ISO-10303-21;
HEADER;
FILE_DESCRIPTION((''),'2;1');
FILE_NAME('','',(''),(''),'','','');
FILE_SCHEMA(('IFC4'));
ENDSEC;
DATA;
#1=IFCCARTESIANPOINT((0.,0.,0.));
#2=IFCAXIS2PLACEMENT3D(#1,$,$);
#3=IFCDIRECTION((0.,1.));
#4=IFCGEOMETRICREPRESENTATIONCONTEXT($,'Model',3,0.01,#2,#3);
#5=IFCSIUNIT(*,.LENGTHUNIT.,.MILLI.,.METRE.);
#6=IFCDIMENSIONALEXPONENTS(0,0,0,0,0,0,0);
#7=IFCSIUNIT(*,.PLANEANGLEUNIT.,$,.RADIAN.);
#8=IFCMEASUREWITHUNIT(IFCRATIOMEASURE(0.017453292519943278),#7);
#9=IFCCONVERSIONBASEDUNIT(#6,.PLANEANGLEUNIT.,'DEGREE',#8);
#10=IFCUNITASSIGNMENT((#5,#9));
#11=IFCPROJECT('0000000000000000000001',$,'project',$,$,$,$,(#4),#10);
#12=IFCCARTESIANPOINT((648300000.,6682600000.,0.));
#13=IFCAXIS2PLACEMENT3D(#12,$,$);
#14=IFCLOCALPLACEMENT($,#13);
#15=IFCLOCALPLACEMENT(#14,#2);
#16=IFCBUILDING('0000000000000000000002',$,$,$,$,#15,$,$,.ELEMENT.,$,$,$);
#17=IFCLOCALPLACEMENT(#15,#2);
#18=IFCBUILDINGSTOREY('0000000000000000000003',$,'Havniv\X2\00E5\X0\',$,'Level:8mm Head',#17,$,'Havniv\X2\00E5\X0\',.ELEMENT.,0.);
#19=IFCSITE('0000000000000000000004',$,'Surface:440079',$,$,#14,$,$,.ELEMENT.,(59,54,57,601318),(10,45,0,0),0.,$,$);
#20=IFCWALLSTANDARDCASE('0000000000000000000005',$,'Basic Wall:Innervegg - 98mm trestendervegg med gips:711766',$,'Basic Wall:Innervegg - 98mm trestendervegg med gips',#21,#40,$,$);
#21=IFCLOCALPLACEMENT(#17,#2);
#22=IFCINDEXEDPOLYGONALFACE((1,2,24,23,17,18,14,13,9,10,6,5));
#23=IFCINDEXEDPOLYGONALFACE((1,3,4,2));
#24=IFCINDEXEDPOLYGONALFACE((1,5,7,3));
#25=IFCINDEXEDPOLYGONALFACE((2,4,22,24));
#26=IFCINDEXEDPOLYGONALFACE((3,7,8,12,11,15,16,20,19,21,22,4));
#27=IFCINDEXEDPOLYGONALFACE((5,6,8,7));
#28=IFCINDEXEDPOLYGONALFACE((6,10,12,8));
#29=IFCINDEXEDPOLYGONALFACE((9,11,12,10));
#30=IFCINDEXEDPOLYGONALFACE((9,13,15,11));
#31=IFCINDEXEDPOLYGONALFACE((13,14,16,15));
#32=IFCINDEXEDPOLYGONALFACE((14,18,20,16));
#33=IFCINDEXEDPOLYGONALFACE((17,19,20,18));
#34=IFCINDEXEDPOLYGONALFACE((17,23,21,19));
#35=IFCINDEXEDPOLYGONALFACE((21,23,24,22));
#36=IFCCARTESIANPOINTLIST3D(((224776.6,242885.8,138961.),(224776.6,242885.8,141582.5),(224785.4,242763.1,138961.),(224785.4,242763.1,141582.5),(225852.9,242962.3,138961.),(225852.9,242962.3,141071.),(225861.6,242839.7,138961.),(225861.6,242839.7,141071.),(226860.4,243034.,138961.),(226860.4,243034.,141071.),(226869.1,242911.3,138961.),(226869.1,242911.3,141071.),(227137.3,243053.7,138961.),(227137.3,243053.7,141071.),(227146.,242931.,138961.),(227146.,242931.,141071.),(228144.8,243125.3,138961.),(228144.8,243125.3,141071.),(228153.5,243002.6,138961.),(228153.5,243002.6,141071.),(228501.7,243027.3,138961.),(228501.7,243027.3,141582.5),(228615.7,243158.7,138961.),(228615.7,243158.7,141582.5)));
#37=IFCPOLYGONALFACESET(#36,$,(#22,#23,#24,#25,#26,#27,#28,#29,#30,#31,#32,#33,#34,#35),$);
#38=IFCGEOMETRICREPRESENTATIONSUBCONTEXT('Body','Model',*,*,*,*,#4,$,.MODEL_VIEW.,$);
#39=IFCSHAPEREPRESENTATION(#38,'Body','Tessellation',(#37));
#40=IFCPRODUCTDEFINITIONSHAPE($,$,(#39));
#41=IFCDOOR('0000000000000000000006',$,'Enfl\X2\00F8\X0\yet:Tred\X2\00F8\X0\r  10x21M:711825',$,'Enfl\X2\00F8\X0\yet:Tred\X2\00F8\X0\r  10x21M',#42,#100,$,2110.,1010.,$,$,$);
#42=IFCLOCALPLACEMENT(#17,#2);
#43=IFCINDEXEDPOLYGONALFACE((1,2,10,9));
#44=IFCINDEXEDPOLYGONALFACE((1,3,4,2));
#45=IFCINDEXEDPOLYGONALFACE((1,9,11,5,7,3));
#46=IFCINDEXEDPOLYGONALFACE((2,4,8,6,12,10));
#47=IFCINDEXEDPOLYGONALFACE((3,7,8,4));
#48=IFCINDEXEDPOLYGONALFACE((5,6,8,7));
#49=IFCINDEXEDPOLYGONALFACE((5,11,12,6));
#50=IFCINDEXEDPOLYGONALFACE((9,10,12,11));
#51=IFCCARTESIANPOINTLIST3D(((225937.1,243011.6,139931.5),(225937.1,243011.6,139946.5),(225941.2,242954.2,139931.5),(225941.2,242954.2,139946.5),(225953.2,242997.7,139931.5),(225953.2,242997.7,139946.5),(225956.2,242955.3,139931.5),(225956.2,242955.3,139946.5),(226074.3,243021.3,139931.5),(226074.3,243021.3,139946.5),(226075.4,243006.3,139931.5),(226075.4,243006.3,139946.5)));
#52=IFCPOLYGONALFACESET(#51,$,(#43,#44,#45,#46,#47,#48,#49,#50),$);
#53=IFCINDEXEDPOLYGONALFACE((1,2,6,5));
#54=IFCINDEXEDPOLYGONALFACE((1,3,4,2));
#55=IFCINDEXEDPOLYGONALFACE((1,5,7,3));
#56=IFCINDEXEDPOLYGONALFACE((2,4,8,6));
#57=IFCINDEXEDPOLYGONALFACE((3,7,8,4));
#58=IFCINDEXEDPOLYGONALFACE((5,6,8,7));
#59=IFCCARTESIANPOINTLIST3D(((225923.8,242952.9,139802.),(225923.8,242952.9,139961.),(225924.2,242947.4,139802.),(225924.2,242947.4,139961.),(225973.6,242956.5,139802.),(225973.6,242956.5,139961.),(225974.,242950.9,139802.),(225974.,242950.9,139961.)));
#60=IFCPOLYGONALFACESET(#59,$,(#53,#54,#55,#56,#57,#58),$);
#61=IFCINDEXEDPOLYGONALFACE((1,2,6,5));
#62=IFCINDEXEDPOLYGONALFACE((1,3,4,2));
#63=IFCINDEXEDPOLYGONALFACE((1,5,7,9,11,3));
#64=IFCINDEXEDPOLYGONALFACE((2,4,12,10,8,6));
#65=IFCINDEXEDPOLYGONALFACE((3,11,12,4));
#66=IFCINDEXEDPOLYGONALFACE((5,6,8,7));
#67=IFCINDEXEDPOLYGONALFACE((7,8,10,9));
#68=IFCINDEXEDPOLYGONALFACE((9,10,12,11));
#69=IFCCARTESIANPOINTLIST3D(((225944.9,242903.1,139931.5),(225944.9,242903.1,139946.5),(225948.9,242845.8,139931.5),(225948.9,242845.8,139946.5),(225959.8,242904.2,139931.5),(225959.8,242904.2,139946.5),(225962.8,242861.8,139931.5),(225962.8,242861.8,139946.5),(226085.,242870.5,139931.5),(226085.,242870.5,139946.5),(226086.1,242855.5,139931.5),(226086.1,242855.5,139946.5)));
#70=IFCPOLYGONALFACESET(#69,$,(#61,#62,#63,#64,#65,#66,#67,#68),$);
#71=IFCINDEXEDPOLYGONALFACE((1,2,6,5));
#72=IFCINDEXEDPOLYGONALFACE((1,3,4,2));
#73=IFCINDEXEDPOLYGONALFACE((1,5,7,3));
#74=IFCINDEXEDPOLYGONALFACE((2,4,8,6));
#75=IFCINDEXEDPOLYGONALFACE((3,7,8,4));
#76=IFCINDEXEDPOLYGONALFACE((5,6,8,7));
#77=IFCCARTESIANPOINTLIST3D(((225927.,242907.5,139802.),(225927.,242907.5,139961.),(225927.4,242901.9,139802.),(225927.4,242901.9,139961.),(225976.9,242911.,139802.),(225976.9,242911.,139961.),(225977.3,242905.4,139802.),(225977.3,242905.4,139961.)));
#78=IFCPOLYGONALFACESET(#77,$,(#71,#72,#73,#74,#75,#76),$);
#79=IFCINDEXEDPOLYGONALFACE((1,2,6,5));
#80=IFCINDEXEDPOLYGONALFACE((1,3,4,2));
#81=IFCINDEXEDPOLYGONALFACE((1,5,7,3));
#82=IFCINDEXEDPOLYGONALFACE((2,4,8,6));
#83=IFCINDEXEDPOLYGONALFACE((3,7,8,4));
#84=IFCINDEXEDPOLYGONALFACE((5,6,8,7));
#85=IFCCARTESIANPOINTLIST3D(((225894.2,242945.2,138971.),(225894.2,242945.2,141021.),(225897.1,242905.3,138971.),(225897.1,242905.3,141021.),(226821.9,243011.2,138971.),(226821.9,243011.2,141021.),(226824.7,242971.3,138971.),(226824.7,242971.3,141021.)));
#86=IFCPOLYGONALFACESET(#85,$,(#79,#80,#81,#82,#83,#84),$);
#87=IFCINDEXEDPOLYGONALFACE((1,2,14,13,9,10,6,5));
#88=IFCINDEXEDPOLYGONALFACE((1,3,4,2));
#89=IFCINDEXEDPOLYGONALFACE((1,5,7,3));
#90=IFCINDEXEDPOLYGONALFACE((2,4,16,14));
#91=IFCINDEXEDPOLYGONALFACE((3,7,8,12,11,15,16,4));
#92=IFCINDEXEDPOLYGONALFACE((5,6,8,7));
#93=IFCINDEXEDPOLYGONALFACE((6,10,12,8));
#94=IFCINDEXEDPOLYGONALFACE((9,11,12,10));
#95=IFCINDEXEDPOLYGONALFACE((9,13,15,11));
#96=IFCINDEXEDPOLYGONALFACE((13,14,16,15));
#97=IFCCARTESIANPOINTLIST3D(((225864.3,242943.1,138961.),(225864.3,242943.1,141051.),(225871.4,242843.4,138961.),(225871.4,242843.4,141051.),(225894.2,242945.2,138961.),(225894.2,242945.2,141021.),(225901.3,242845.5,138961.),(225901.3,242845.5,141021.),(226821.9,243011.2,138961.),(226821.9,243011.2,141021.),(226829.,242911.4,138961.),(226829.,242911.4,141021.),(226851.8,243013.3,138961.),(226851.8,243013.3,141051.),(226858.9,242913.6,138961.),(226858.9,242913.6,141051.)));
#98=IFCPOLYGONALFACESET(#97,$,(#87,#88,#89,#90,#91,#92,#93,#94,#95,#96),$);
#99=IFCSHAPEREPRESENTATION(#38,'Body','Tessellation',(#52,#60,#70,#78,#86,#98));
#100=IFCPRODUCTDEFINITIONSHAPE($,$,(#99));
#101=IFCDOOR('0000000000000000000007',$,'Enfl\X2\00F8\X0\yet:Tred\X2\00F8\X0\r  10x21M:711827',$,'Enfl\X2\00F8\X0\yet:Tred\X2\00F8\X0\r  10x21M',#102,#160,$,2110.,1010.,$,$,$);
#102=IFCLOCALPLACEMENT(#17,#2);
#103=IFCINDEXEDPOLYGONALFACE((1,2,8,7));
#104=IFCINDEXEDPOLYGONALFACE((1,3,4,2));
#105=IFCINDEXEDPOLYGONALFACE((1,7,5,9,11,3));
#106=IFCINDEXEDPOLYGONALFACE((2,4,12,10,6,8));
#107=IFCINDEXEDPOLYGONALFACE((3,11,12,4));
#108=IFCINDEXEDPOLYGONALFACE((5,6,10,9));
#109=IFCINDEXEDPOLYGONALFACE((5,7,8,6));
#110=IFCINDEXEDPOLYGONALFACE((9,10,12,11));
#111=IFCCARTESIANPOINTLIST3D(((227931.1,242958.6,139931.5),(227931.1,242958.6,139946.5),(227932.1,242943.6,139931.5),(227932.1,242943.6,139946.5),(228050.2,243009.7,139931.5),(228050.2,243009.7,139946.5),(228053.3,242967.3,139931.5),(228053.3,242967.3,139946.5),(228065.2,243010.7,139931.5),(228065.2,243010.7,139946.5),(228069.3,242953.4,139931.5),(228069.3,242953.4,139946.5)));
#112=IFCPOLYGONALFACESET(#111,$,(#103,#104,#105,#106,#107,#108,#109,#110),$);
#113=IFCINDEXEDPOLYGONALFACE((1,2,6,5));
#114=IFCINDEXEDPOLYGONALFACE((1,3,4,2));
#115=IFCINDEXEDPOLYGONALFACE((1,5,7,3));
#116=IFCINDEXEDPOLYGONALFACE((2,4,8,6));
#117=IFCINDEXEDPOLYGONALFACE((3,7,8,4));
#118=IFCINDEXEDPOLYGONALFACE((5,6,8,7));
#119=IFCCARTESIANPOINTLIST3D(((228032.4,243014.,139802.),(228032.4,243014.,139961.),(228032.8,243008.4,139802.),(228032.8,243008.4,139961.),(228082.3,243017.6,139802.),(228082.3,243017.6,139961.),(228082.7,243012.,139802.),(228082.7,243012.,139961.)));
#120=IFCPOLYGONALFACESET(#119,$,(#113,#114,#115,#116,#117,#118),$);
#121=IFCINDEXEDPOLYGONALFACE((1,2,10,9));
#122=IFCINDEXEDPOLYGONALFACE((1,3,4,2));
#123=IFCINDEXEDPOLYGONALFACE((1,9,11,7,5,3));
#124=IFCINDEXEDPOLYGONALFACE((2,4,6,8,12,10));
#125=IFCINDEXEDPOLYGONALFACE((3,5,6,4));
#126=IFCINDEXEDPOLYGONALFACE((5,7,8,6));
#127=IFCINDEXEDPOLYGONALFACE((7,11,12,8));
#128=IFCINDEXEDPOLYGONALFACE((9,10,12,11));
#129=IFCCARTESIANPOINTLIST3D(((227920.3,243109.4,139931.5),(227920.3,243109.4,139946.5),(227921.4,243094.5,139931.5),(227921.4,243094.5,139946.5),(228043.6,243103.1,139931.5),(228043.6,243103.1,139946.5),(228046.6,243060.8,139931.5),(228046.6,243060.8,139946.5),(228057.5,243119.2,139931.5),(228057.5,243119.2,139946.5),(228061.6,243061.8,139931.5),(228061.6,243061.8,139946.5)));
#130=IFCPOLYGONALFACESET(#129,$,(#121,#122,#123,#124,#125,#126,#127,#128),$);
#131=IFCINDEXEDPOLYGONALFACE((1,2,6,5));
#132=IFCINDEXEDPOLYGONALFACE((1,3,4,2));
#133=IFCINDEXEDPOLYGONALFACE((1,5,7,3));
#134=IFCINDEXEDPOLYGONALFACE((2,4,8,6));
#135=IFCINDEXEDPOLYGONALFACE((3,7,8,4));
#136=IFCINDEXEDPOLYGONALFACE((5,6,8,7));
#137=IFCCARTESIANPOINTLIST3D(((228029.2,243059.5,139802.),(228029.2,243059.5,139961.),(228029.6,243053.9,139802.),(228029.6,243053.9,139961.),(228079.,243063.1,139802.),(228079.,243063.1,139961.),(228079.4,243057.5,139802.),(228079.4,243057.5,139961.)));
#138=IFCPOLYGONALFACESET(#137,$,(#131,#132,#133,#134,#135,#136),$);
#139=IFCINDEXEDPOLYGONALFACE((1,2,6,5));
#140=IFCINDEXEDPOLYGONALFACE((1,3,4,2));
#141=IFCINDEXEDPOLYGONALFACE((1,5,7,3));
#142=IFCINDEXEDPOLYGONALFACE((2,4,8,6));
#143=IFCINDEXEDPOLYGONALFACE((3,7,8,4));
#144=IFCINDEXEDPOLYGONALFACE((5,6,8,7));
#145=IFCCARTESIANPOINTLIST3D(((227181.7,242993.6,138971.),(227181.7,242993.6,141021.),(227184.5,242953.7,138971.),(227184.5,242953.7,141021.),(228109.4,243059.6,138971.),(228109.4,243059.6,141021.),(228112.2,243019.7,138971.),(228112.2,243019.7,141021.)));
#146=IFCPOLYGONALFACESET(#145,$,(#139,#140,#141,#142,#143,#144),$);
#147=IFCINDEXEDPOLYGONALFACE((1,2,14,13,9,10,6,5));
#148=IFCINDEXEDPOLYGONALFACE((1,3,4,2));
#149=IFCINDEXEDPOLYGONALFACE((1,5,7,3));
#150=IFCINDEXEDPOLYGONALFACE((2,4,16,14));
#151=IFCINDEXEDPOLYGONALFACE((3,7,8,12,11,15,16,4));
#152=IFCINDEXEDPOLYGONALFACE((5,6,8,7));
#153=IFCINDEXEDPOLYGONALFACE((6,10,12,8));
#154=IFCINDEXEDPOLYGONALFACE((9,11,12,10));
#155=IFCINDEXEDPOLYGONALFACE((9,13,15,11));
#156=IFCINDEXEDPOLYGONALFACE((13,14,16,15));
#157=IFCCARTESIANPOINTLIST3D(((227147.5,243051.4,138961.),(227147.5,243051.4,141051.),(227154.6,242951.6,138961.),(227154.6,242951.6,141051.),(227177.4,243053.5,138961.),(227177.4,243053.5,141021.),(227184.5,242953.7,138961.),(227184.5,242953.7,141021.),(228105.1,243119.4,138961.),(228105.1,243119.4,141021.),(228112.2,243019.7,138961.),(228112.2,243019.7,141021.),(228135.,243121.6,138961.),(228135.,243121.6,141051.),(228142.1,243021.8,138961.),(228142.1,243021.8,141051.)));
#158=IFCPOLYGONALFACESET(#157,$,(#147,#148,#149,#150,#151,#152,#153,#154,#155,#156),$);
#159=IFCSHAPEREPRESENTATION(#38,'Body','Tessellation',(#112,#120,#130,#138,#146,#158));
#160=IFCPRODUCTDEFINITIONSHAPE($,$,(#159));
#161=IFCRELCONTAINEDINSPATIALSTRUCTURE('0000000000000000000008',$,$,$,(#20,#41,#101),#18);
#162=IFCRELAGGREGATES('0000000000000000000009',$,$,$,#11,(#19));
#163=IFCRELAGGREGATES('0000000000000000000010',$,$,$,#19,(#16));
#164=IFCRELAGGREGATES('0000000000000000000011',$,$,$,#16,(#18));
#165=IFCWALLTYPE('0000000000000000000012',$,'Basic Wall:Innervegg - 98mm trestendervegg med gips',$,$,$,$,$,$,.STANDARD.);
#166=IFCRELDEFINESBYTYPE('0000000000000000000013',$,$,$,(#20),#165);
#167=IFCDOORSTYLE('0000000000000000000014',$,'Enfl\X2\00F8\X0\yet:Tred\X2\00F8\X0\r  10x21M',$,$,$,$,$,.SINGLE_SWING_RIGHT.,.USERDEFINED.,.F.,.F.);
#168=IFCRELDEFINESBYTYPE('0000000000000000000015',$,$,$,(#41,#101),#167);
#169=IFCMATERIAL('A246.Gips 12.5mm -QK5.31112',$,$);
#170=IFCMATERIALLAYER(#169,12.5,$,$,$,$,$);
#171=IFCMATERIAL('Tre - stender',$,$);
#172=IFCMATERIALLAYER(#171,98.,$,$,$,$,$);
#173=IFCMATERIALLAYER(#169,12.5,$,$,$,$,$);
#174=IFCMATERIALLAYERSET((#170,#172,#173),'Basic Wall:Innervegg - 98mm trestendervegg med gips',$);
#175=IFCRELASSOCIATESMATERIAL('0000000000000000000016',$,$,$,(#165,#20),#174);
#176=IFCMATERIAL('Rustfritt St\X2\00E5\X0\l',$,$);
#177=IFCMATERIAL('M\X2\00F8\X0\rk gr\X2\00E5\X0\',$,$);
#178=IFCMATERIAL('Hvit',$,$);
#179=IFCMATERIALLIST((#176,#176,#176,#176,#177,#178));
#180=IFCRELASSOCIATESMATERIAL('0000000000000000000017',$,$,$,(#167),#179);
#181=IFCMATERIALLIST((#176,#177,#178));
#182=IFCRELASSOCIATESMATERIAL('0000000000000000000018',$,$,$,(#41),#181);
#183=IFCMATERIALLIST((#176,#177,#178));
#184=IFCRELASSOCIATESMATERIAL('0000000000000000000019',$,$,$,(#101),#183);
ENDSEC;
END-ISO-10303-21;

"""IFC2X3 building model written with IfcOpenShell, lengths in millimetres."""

from ifc_helpers import new_model, entity, si_unit, converted_unit, direction, frame, frame_2d, origin, origin_2d_with_axis, place, context, subcontext, project, spatial, polyline, rectangle, outline, extrude, clip, bounded_halfspace, source, transform, mapped, material, material_list, layer, layer_set, layer_usage, type_object, type_shapes, element, fill, save


model = new_model("IFC2X3")

# Units and contexts
model_context = context("Model", 3, precision=0.01, world=origin(), true_north=direction((0.0, 1.0)))
body_context = subcontext(model_context, "Body", "Model", "MODEL_VIEW")
ifc_project = project(units=[si_unit("LENGTHUNIT", "METRE", prefix="MILLI"), converted_unit("PLANEANGLEUNIT", "DEGREE", entity("IfcRatioMeasure", 0.017453292519943278), si_unit("PLANEANGLEUNIT", "RADIAN"), dimensions=[0, 0, 0, 0, 0, 0, 0])], contexts=[model_context])

# Site, building, storey
site_placement = place(None, frame((648300000.0, 6682600000.0, 0.0)))
site = spatial("IfcSite", under=ifc_project, at=site_placement, Name="Surface:440079", CompositionType="ELEMENT", RefLatitude=(59, 54, 57, 601318), RefLongitude=(10, 45, 0, 0), RefElevation=0.0)
building_placement = place(site_placement, origin())
building = spatial("IfcBuilding", under=site, at=building_placement, CompositionType="ELEMENT")
storey_placement = place(building_placement, origin())
storey = spatial("IfcBuildingStorey", under=building, at=storey_placement, Name="Havnivå", ObjectType="Level:8mm Head", LongName="Havnivå", CompositionType="ELEMENT", Elevation=0.0)

# Shared definitions
ifc_material_1 = material(Name="A246.Gips 12.5mm -QK5.31112")
ifc_layer_1 = layer(ifc_material_1, 12.5)
ifc_material_2 = material(Name="Tre - stender")
ifc_layer_2 = layer(ifc_material_2, 98.0)
ifc_layer_3 = layer(ifc_material_1, 12.5)
ifc_layer_set = layer_set([ifc_layer_1, ifc_layer_2, ifc_layer_3], Name="Basic Wall:Innervegg - 98mm trestendervegg med gips")
wall_type = type_object("IfcWallType", Name="Basic Wall:Innervegg - 98mm trestendervegg med gips", PredefinedType="STANDARD", material=ifc_layer_set)
ifc_material_3 = material(Name="Rustfritt Stål")
ifc_material_4 = material(Name="Mørk grå")
ifc_material_5 = material(Name="Hvit")
ifc_material_list_1 = material_list([ifc_material_3, ifc_material_3, ifc_material_3, ifc_material_3, ifc_material_4, ifc_material_5])
door_style_1 = type_object("IfcDoorStyle", Name="Enfløyet:Tredør  10x21M", ConstructionType="USERDEFINED", OperationType="SINGLE_SWING_RIGHT", ParameterTakesPrecedence=False, Sizeable=False, material=ifc_material_list_1)
shared_shape_1 = source(origin(), body_context, "Body", "SweptSolid", [
    extrude(outline(polyline([(-50.8, -33.3), (-35.8, -33.3), (-35.8, 9.2), (86.7, 9.2), (86.7, 24.2), (-50.8, 24.2), (-50.8, -33.3)])), frame((138.3, 141.9, 970.5)), (0.0, 0.0, 1.0), 15.0),
    extrude(rectangle(XDim=50.0, YDim=5.6, at=frame_2d((0.0, 0.0), x_axis=(1.0, 0.0))), frame((95.0, 105.8, 841.0), z_axis=(0.0, 0.0, 1.0), x_axis=(-1.0, 0.0, 0.0)), (0.0, 0.0, 1.0), 159.0),
    extrude(outline(polyline([(-33.3, -50.8), (24.2, -50.8), (24.2, 86.7), (9.2, 86.7), (9.2, -35.8), (-33.3, -35.8), (-33.3, -50.8)])), frame((138.3, 24.1, 970.5), z_axis=(0.0, 0.0, 1.0), x_axis=(0.0, -1.0, 0.0)), (0.0, 0.0, 1.0), 15.0),
    extrude(rectangle(XDim=5.6, YDim=50.0, at=frame_2d((0.0, 0.0), x_axis=(1.0, 0.0))), frame((95.0, 60.2, 841.0), z_axis=(0.0, 0.0, 1.0), x_axis=(0.0, 1.0, 0.0)), (0.0, 0.0, 1.0), 159.0),
    extrude(rectangle(XDim=40.0, YDim=930.0, at=origin_2d_with_axis()), frame((505.0, 83.0, 10.0), z_axis=(0.0, 0.0, 1.0), x_axis=(0.0, -1.0, 0.0)), (0.0, 0.0, 1.0), 2050.0),
    extrude(outline(polyline([(-1037.5, -495.0), (1052.5, -495.0), (1052.5, 495.0), (-1037.5, 495.0), (-1037.5, 465.0), (1022.5, 465.0), (1022.5, -465.0), (-1037.5, -465.0), (-1037.5, -495.0)])), frame((505.0, 3.0, 1037.5), z_axis=(0.0, 1.0, 0.0), x_axis=(0.0, 0.0, 1.0)), (0.0, 0.0, 1.0), 100.0),
])
type_shapes(door_style_1, [shared_shape_1])

# Wall, openings, doors
ifc_layer_usage_1 = layer_usage(ifc_layer_set, "AXIS2", "NEGATIVE", 61.5)
wall_1_placement = place(storey_placement, frame((228620.0, 243097.4, 138961.0), z_axis=(0.0, 0.0, 1.0), x_axis=(-0.997483, -0.070908, 0.0)))
wall_1 = element("IfcWallStandardCase", 1, at=wall_1_placement, inside=storey, type_object=wall_type, material=ifc_layer_usage_1, Name="Basic Wall:Innervegg - 98mm trestendervegg med gips:711766", ObjectType="Basic Wall:Innervegg - 98mm trestendervegg med gips", context=body_context, shape_type="Clipping", body=[
    clip(extrude(outline(polyline([(0.0, -61.5), (173.9, -61.5), (3848.7, -61.5), (3848.7, 61.5), (123.0, 61.5), (0.0, -61.5)])), origin(), (0.0, 0.0, 1.0), 2621.5), bounded_halfspace(frame((0.0, -61.5, 2621.5), z_axis=(0.0, 0.0, -1.0), x_axis=(-1.0, 0.0, 0.0)), True, frame((0.0, -61.5, 2621.5)), polyline([(0.0, 0.0), (53019.4, 0.0), (1173085.9, 0.0), (1173085.9, 37490.4), (37490.4, 37490.4), (0.0, 0.0)]))),
])
opening_1_placement = place(wall_1_placement, frame((2769.7, 61.5, 0.0)))
opening_1 = element("IfcOpeningElement", 2, at=opening_1_placement, cuts=wall_1, ObjectType="Opening", context=body_context, shape_type="SweptSolid", body=[
    extrude(rectangle(XDim=2110.0, YDim=1010.0, at=frame_2d((1055.0, 505.0), x_axis=(1.0, 0.0))), frame((0.0, 0.0, 0.0), z_axis=(0.0, -1.0, 0.0), x_axis=(0.0, 0.0, 1.0)), (0.0, 0.0, 1.0), 123.0),
])
opening_2_placement = place(wall_1_placement, frame((472.1, -61.5, 0.0)))
opening_2 = element("IfcOpeningElement", 3, at=opening_2_placement, cuts=wall_1, ObjectType="Opening", context=body_context, shape_type="SweptSolid", body=[
    extrude(rectangle(XDim=2110.0, YDim=1010.0, at=frame_2d((1055.0, 505.0), x_axis=(1.0, 0.0))), frame((0.0, 0.0, 0.0), z_axis=(0.0, 1.0, 0.0), x_axis=(0.0, 0.0, 1.0)), (0.0, 0.0, 1.0), 123.0),
])
ifc_material_list_2 = material_list([ifc_material_3, ifc_material_4, ifc_material_5])
door_1_placement = place(opening_1_placement, frame((0.0, 0.0, 0.0), z_axis=(0.0, 0.0, 1.0), x_axis=(-1.0, 0.0, 0.0)))
door_1 = element("IfcDoor", 4, at=door_1_placement, inside=storey, type_object=door_style_1, material=ifc_material_list_2, Name="Enfløyet:Tredør  10x21M:711825", ObjectType="Enfløyet:Tredør  10x21M", OverallHeight=2110.0, OverallWidth=1010.0, context=body_context, shape_type="MappedRepresentation", body=[
    mapped(shared_shape_1, transform((0.0, 0.0, 0.0), scale=1.0)),
])
fill(opening_1, door_1)
ifc_material_list_3 = material_list([ifc_material_3, ifc_material_4, ifc_material_5])
door_2_placement = place(opening_2_placement, origin())
door_2 = element("IfcDoor", 5, at=door_2_placement, inside=storey, type_object=door_style_1, material=ifc_material_list_3, Name="Enfløyet:Tredør  10x21M:711827", ObjectType="Enfløyet:Tredør  10x21M", OverallHeight=2110.0, OverallWidth=1010.0, context=body_context, shape_type="MappedRepresentation", body=[
    mapped(shared_shape_1, transform((0.0, 0.0, 0.0), scale=1.0)),
])
fill(opening_2, door_2)

save(model, "model.ifc")
